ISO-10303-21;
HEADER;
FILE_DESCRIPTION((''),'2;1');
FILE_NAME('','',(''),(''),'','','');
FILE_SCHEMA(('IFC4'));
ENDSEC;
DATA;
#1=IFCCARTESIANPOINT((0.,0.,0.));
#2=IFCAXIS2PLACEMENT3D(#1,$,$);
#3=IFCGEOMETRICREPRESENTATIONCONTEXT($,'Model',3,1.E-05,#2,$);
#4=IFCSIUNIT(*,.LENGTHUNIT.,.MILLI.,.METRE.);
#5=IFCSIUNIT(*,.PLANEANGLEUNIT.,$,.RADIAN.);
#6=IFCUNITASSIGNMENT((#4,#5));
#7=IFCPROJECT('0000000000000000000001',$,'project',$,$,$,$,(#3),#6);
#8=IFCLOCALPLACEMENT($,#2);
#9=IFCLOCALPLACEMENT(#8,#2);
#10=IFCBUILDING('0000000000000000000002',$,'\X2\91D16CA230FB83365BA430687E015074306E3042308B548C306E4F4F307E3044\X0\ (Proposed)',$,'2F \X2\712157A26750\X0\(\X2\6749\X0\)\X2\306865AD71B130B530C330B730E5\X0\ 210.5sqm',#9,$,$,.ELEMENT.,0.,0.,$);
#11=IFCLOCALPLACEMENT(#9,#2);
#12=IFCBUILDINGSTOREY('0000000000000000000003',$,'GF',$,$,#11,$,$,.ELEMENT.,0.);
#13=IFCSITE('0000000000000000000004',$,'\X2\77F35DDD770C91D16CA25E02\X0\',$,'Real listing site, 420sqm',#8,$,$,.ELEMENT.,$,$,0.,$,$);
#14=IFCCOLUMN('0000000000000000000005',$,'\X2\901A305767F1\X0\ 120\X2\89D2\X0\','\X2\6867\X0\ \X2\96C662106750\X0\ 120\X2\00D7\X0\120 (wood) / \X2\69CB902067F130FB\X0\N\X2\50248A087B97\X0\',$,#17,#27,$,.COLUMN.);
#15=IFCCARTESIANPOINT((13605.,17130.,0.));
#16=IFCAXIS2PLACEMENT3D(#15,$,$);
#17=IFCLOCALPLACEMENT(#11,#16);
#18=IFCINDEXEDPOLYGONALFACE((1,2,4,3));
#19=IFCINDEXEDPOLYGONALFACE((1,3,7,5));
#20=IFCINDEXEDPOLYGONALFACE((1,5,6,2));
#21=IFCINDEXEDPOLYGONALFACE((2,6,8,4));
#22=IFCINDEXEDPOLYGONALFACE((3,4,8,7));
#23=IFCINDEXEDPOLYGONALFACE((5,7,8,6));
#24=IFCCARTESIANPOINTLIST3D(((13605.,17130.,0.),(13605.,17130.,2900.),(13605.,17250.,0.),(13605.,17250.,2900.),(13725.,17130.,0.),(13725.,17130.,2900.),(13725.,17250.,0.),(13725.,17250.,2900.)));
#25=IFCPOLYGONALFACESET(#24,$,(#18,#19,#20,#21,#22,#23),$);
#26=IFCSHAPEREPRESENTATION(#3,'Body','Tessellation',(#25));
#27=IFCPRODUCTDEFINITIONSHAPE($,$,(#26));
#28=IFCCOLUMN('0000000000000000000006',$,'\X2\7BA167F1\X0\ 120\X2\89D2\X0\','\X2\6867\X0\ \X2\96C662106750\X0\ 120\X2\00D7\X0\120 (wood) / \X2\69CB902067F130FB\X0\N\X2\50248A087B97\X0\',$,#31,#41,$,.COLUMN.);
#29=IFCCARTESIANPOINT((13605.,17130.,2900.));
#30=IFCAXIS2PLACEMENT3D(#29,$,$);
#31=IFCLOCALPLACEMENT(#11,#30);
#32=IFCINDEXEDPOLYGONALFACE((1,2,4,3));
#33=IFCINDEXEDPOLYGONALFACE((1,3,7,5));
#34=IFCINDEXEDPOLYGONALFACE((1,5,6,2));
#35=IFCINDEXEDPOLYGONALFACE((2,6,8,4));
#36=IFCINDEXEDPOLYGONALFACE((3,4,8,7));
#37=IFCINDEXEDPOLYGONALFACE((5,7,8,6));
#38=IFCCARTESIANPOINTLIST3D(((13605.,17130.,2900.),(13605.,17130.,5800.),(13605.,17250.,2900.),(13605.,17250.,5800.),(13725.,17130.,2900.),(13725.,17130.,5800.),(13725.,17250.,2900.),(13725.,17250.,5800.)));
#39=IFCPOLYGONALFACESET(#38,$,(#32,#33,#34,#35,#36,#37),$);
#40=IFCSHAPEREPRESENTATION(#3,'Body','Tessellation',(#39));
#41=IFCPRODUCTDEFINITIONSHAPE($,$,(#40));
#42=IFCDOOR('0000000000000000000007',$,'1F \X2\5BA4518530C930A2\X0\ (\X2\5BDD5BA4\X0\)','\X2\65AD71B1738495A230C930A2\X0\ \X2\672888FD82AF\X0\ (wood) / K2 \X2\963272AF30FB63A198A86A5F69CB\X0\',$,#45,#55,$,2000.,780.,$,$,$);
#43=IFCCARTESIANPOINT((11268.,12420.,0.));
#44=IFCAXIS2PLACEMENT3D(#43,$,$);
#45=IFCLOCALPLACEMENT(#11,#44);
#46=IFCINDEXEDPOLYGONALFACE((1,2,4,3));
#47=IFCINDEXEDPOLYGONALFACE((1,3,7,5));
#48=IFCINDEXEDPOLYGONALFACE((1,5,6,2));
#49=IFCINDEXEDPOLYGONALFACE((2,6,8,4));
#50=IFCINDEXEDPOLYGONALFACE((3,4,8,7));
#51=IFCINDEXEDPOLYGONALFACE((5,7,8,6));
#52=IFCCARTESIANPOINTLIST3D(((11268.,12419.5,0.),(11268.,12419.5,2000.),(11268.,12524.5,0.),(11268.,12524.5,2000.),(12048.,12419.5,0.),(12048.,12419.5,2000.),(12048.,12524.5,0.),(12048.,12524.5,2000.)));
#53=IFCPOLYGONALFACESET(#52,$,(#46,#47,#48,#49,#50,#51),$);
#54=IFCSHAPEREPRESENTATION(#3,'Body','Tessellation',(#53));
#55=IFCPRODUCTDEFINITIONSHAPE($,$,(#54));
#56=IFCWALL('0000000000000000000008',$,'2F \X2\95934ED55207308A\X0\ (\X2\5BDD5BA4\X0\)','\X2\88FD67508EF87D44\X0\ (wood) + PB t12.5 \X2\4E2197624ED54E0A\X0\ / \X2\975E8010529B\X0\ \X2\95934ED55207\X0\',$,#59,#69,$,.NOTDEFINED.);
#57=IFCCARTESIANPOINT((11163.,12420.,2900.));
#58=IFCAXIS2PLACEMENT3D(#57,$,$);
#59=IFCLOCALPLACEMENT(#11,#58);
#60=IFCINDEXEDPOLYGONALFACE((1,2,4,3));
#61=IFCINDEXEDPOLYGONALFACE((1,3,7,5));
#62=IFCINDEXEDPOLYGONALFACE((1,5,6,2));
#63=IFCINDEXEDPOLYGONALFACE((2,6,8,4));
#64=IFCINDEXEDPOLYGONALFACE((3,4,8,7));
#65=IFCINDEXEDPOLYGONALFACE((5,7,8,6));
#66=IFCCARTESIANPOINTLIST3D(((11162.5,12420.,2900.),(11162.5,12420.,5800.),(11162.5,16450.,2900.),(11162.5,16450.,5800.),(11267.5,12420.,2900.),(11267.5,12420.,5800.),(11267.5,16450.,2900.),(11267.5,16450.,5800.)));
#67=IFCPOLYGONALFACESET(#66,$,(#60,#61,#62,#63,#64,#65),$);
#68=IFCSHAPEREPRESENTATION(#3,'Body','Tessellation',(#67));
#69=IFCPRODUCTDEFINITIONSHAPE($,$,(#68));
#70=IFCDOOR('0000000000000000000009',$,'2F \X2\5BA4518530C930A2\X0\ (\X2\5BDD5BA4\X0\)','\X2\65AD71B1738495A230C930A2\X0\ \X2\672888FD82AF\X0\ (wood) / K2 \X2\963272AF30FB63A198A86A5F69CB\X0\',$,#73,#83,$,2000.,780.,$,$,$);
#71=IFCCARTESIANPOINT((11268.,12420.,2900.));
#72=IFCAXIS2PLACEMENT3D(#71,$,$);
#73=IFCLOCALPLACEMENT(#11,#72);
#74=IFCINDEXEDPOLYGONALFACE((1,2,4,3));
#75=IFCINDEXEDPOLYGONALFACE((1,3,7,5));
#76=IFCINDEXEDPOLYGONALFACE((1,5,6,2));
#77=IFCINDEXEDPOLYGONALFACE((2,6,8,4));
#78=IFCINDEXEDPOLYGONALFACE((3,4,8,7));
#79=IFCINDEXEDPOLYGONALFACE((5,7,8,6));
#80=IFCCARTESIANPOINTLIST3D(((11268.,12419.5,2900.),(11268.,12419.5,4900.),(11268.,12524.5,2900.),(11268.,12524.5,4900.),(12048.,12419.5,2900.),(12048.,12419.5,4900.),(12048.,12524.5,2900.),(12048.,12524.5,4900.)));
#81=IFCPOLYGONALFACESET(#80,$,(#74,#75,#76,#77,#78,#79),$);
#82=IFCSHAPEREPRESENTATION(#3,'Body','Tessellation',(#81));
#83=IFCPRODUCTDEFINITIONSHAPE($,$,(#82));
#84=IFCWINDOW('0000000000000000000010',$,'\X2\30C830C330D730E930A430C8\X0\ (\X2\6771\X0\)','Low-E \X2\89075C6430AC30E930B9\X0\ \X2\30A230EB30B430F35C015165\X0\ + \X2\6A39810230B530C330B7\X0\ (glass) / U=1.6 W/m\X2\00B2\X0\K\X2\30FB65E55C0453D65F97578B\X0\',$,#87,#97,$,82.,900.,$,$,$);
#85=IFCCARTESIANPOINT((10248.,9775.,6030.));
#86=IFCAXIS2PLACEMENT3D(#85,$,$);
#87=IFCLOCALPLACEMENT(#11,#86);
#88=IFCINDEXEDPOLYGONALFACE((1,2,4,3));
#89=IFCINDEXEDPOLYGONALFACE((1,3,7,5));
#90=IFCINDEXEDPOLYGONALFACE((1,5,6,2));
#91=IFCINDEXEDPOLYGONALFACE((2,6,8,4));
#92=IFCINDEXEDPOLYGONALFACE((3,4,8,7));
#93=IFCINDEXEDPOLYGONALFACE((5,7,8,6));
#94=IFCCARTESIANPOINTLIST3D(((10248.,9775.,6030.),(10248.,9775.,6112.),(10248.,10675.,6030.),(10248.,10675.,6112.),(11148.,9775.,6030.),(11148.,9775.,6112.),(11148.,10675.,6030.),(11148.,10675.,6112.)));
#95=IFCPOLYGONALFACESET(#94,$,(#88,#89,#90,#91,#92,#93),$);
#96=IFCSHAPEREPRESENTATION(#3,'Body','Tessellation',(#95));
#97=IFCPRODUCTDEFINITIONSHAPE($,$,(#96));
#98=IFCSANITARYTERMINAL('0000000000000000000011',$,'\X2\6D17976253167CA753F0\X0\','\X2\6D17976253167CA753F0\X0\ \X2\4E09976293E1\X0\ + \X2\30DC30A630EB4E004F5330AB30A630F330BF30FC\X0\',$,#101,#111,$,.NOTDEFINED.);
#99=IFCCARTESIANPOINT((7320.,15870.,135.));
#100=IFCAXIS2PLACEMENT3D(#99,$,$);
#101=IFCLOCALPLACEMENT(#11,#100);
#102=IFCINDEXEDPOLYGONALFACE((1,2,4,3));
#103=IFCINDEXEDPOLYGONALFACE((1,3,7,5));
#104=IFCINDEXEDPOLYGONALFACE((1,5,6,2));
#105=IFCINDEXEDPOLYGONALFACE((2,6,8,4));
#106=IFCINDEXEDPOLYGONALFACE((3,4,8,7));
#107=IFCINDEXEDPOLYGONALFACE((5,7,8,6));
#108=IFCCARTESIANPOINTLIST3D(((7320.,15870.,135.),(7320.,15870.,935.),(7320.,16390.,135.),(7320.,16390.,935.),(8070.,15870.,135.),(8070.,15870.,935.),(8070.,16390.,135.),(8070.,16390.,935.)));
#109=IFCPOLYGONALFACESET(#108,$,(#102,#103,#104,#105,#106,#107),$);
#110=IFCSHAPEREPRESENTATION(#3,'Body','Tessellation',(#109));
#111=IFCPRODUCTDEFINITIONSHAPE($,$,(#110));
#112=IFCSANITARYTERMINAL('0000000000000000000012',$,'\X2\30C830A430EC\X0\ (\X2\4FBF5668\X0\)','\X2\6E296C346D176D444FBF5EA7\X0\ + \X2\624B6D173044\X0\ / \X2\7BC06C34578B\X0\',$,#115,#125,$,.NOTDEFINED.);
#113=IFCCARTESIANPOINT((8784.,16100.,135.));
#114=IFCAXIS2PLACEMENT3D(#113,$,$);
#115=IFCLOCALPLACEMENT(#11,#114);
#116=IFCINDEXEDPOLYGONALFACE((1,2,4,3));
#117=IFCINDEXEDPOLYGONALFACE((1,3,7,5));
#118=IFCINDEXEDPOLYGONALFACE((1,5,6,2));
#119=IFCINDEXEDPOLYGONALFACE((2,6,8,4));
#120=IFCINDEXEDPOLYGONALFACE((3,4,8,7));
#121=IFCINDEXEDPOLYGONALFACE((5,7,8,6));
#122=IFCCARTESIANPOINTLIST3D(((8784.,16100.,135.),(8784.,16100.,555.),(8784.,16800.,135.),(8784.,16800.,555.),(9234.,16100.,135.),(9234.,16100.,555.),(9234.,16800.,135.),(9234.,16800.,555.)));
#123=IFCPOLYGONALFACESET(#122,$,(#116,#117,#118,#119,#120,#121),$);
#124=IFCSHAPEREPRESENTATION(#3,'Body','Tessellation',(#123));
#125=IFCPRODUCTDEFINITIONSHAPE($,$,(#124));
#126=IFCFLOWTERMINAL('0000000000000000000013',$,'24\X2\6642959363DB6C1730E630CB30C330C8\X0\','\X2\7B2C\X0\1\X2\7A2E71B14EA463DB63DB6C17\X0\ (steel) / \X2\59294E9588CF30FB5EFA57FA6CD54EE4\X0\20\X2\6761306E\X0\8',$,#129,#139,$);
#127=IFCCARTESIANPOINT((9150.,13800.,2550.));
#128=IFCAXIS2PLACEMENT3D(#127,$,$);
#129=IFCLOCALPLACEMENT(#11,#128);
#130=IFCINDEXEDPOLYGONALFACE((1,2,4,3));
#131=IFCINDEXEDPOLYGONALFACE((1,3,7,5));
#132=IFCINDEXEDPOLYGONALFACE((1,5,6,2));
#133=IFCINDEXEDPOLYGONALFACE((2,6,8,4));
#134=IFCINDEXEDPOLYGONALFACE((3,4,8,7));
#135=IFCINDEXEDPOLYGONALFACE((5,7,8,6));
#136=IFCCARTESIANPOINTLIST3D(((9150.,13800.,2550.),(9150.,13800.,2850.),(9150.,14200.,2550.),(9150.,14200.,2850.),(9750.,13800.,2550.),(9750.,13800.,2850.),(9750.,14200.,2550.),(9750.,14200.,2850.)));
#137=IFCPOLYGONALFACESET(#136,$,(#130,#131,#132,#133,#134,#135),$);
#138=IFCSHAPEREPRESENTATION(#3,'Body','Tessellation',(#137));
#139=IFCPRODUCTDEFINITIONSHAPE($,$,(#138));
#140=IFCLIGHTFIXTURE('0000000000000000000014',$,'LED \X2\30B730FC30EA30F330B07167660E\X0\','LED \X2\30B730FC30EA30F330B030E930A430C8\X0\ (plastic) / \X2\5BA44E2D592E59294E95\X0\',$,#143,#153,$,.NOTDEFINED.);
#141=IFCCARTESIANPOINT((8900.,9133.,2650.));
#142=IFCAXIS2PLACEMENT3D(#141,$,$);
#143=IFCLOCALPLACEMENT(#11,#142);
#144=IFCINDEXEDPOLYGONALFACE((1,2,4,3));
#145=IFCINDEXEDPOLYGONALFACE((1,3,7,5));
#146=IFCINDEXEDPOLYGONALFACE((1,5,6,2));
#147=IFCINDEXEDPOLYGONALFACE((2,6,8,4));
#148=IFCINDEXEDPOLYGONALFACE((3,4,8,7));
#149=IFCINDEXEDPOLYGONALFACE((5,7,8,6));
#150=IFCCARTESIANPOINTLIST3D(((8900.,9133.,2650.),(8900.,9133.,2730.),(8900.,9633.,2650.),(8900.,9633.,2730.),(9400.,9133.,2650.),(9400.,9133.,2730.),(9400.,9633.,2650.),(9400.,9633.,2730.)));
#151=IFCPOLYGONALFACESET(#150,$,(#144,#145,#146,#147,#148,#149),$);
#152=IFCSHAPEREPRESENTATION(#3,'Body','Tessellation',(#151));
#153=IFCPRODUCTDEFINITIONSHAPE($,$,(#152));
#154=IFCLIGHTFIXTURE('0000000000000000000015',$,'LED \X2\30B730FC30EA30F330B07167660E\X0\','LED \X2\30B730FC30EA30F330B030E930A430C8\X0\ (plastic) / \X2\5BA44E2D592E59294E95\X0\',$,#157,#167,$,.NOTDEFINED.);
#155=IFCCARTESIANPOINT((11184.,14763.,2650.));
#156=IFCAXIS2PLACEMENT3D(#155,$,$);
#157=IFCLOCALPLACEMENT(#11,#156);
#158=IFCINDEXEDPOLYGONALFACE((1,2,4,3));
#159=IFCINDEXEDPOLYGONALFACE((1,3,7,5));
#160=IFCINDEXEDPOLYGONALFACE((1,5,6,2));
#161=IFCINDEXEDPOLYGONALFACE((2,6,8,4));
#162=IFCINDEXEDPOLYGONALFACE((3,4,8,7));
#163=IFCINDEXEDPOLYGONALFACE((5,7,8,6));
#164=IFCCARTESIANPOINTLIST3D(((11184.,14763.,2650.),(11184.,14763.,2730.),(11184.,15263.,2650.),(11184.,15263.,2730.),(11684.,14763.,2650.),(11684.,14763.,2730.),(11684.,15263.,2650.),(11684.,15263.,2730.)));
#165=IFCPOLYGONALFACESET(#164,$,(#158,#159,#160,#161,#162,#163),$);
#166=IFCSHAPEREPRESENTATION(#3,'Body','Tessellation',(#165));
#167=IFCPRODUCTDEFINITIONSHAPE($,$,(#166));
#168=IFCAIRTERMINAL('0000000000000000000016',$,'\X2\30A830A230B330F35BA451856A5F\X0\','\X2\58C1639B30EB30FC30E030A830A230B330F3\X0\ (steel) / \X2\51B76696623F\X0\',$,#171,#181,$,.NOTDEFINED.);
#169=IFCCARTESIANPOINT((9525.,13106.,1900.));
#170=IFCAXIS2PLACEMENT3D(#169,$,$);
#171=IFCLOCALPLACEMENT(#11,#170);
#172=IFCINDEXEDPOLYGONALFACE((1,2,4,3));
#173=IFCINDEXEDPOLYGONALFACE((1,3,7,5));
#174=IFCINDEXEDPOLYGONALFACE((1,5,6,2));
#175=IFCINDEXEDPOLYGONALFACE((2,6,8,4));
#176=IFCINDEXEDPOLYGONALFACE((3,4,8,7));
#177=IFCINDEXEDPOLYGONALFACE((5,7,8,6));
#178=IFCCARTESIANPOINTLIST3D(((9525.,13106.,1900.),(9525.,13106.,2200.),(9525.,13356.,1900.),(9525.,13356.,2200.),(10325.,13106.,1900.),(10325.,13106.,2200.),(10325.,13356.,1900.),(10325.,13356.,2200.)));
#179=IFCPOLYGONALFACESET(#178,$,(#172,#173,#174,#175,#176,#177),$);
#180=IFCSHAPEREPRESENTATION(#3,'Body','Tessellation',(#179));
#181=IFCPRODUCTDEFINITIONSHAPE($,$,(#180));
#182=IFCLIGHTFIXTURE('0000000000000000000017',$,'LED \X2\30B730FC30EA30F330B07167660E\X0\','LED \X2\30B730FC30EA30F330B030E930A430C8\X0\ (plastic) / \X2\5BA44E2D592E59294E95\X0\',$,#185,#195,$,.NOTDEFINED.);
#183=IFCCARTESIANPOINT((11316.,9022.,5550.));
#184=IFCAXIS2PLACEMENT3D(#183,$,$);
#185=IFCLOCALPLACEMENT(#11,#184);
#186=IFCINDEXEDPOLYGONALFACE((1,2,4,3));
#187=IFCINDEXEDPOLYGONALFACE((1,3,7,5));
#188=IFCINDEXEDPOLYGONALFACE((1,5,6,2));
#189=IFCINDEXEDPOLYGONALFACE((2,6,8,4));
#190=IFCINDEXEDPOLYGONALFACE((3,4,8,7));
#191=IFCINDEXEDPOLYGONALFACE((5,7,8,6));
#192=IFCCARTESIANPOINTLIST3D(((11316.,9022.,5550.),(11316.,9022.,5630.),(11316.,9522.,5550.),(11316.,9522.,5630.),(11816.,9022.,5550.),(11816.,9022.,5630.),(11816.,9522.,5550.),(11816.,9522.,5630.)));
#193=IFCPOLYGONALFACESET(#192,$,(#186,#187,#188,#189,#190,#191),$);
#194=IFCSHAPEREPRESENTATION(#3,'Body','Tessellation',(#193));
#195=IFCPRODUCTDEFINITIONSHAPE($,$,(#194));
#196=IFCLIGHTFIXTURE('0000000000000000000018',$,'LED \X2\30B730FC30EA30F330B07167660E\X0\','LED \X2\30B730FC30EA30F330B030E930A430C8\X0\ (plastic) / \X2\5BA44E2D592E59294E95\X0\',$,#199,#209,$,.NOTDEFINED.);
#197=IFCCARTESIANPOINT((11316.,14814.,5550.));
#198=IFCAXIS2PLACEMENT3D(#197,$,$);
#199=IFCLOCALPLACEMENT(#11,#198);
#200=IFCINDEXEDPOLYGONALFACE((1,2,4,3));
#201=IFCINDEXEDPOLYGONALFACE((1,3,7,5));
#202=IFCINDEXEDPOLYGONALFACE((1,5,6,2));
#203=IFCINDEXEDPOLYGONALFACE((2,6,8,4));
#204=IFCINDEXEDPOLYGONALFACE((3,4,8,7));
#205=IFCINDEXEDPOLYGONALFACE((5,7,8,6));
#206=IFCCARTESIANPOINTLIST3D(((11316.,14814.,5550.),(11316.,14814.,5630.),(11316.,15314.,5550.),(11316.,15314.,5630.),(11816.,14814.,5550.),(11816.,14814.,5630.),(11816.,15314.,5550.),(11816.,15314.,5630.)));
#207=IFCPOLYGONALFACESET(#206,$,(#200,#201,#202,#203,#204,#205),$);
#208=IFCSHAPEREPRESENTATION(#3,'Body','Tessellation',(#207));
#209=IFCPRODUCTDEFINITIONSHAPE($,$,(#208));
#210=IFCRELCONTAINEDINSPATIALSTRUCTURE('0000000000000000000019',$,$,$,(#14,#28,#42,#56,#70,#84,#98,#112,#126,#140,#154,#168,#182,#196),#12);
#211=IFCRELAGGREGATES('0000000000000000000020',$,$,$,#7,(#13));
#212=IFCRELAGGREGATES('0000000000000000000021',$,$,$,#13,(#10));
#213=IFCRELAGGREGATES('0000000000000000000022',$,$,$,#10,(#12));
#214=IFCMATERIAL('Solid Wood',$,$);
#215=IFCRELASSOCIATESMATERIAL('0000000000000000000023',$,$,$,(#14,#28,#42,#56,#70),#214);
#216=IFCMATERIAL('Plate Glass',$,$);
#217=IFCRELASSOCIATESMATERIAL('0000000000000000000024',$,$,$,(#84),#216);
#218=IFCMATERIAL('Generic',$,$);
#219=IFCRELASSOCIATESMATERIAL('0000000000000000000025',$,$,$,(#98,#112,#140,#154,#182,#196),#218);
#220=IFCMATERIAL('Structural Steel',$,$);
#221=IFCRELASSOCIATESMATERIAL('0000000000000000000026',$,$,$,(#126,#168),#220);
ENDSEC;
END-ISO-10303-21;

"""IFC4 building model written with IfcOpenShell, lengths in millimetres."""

from ifc_helpers import new_model, si_unit, frame, frame_2d, origin, place, context, project, spatial, rectangle, extrude, material, element, save


model = new_model("IFC4")

# Units and contexts
model_context = context("Model", 3, precision=1e-05, world=origin())
ifc_project = project(units=[si_unit("LENGTHUNIT", "METRE", prefix="MILLI"), si_unit("PLANEANGLEUNIT", "RADIAN")], contexts=[model_context])

# Site, building, storey
site_placement = place(None, origin())
site = spatial("IfcSite", under=ifc_project, at=site_placement, Name="石川県金沢市", ObjectType="Real listing site, 420sqm", CompositionType="ELEMENT", RefElevation=0.0)
building_placement = place(site_placement, origin())
building = spatial("IfcBuilding", under=site, at=building_placement, Name="金沢・茶室と縁側のある和の住まい (Proposed)", ObjectType="2F 無垢材(杉)と断熱サッシュ 210.5sqm", CompositionType="ELEMENT", ElevationOfRefHeight=0.0, ElevationOfTerrain=0.0)
storey_placement = place(building_placement, origin())
storey = spatial("IfcBuildingStorey", under=building, at=storey_placement, Name="GF", CompositionType="ELEMENT", Elevation=0.0)

# Columns
ifc_material_1 = material(Name="Solid Wood")
column_1_placement = place(storey_placement, frame((13605.0, 17130.0, 0.0)))
element("IfcColumn", 1, at=column_1_placement, inside=storey, material=ifc_material_1, Name="通し柱 120角", Description="桧 集成材 120×120 (wood) / 構造柱・N値計算", PredefinedType="COLUMN", context=model_context, shape_type="SweptSolid", body=[
    extrude(rectangle(XDim=120.0, YDim=120.0, at=frame_2d((60.0, 60.0))), frame((13605.0, 17130.0, 0.0)), (0.0, 0.0, 1.0), 2900.0),
])
column_2_placement = place(storey_placement, frame((13605.0, 17130.0, 2900.0)))
element("IfcColumn", 2, at=column_2_placement, inside=storey, material=ifc_material_1, Name="管柱 120角", Description="桧 集成材 120×120 (wood) / 構造柱・N値計算", PredefinedType="COLUMN", context=model_context, shape_type="SweptSolid", body=[
    extrude(rectangle(XDim=120.0, YDim=120.0, at=frame_2d((60.0, 60.0))), frame((13605.0, 17130.0, 2900.0)), (0.0, 0.0, 1.0), 2900.0),
])

# Door
door_1_placement = place(storey_placement, frame((11268.0, 12420.0, 0.0)))
element("IfcDoor", 3, at=door_1_placement, inside=storey, material=ifc_material_1, Name="1F 室内ドア (寝室)", Description="断熱玄関ドア 木製芯 (wood) / K2 防犯・採風機構", OverallHeight=2000.0, OverallWidth=780.0, context=model_context, shape_type="SweptSolid", body=[
    extrude(rectangle(XDim=780.0, YDim=105.0, at=frame_2d((390.0, 52.0))), frame((11268.0, 12420.0, 0.0)), (0.0, 0.0, 1.0), 2000.0),
])

# Wall
wall_1_placement = place(storey_placement, frame((11163.0, 12420.0, 2900.0)))
element("IfcWall", 4, at=wall_1_placement, inside=storey, material=ifc_material_1, Name="2F 間仕切り (寝室)", Description="製材軸組 (wood) + PB t12.5 両面仕上 / 非耐力 間仕切", PredefinedType="NOTDEFINED", context=model_context, shape_type="SweptSolid", body=[
    extrude(rectangle(XDim=105.0, YDim=4030.0, at=frame_2d((52.0, 2015.0))), frame((11163.0, 12420.0, 2900.0)), (0.0, 0.0, 1.0), 2900.0),
])

# Door
door_2_placement = place(storey_placement, frame((11268.0, 12420.0, 2900.0)))
element("IfcDoor", 5, at=door_2_placement, inside=storey, material=ifc_material_1, Name="2F 室内ドア (寝室)", Description="断熱玄関ドア 木製芯 (wood) / K2 防犯・採風機構", OverallHeight=2000.0, OverallWidth=780.0, context=model_context, shape_type="SweptSolid", body=[
    extrude(rectangle(XDim=780.0, YDim=105.0, at=frame_2d((390.0, 52.0))), frame((11268.0, 12420.0, 2900.0)), (0.0, 0.0, 1.0), 2000.0),
])

# Window
ifc_material_2 = material(Name="Plate Glass")
window_placement = place(storey_placement, frame((10248.0, 9775.0, 6030.0)))
element("IfcWindow", 6, at=window_placement, inside=storey, material=ifc_material_2, Name="トップライト (東)", Description="Low-E 複層ガラス アルゴン封入 + 樹脂サッシ (glass) / U=1.6 W/m²K・日射取得型", OverallHeight=82.0, OverallWidth=900.0, context=model_context, shape_type="SweptSolid", body=[
    extrude(rectangle(XDim=900.0, YDim=900.0, at=frame_2d((450.0, 450.0))), frame((10248.0, 9775.0, 6030.0)), (0.0, 0.0, 1.0), 82.0),
])

# Sanitary terminals
ifc_material_3 = material(Name="Generic")
sanitary_terminal_1_placement = place(storey_placement, frame((7320.0, 15870.0, 135.0)))
element("IfcSanitaryTerminal", 7, at=sanitary_terminal_1_placement, inside=storey, material=ifc_material_3, Name="洗面化粧台", Description="洗面化粧台 三面鏡 + ボウル一体カウンター", PredefinedType="NOTDEFINED", context=model_context, shape_type="SweptSolid", body=[
    extrude(rectangle(XDim=750.0, YDim=520.0, at=frame_2d((375.0, 260.0))), frame((7320.0, 15870.0, 135.0)), (0.0, 0.0, 1.0), 800.0),
])
sanitary_terminal_2_placement = place(storey_placement, frame((8784.0, 16100.0, 135.0)))
element("IfcSanitaryTerminal", 8, at=sanitary_terminal_2_placement, inside=storey, material=ifc_material_3, Name="トイレ (便器)", Description="温水洗浄便座 + 手洗い / 節水型", PredefinedType="NOTDEFINED", context=model_context, shape_type="SweptSolid", body=[
    extrude(rectangle(XDim=450.0, YDim=700.0, at=frame_2d((225.0, 350.0))), frame((8784.0, 16100.0, 135.0)), (0.0, 0.0, 1.0), 420.0),
])

# Flow terminal
ifc_material_4 = material(Name="Structural Steel")
flow_terminal_placement = place(storey_placement, frame((9150.0, 13800.0, 2550.0)))
element("IfcFlowTerminal", 9, at=flow_terminal_placement, inside=storey, material=ifc_material_4, Name="24時間換気ユニット", Description="第1種熱交換換気 (steel) / 天井裏・建基法令20条の8", context=model_context, shape_type="SweptSolid", body=[
    extrude(rectangle(XDim=600.0, YDim=400.0, at=frame_2d((300.0, 200.0))), frame((9150.0, 13800.0, 2550.0)), (0.0, 0.0, 1.0), 300.0),
])

# Light fixtures
light_fixture_1_placement = place(storey_placement, frame((8900.0, 9133.0, 2650.0)))
element("IfcLightFixture", 10, at=light_fixture_1_placement, inside=storey, material=ifc_material_3, Name="LED シーリング照明", Description="LED シーリングライト (plastic) / 室中央天井", PredefinedType="NOTDEFINED", context=model_context, shape_type="SweptSolid", body=[
    extrude(rectangle(XDim=500.0, YDim=500.0, at=frame_2d((250.0, 250.0))), frame((8900.0, 9133.0, 2650.0)), (0.0, 0.0, 1.0), 80.0),
])
light_fixture_2_placement = place(storey_placement, frame((11184.0, 14763.0, 2650.0)))
element("IfcLightFixture", 11, at=light_fixture_2_placement, inside=storey, material=ifc_material_3, Name="LED シーリング照明", Description="LED シーリングライト (plastic) / 室中央天井", PredefinedType="NOTDEFINED", context=model_context, shape_type="SweptSolid", body=[
    extrude(rectangle(XDim=500.0, YDim=500.0, at=frame_2d((250.0, 250.0))), frame((11184.0, 14763.0, 2650.0)), (0.0, 0.0, 1.0), 80.0),
])

# Air terminal
air_terminal_placement = place(storey_placement, frame((9525.0, 13106.0, 1900.0)))
element("IfcAirTerminal", 12, at=air_terminal_placement, inside=storey, material=ifc_material_4, Name="エアコン室内機", Description="壁掛ルームエアコン (steel) / 冷暖房", PredefinedType="NOTDEFINED", context=model_context, shape_type="SweptSolid", body=[
    extrude(rectangle(XDim=800.0, YDim=250.0, at=frame_2d((400.0, 125.0))), frame((9525.0, 13106.0, 1900.0)), (0.0, 0.0, 1.0), 300.0),
])

# Light fixtures
light_fixture_3_placement = place(storey_placement, frame((11316.0, 9022.0, 5550.0)))
element("IfcLightFixture", 13, at=light_fixture_3_placement, inside=storey, material=ifc_material_3, Name="LED シーリング照明", Description="LED シーリングライト (plastic) / 室中央天井", PredefinedType="NOTDEFINED", context=model_context, shape_type="SweptSolid", body=[
    extrude(rectangle(XDim=500.0, YDim=500.0, at=frame_2d((250.0, 250.0))), frame((11316.0, 9022.0, 5550.0)), (0.0, 0.0, 1.0), 80.0),
])
light_fixture_4_placement = place(storey_placement, frame((11316.0, 14814.0, 5550.0)))
element("IfcLightFixture", 14, at=light_fixture_4_placement, inside=storey, material=ifc_material_3, Name="LED シーリング照明", Description="LED シーリングライト (plastic) / 室中央天井", PredefinedType="NOTDEFINED", context=model_context, shape_type="SweptSolid", body=[
    extrude(rectangle(XDim=500.0, YDim=500.0, at=frame_2d((250.0, 250.0))), frame((11316.0, 14814.0, 5550.0)), (0.0, 0.0, 1.0), 80.0),
])

save(model, "model.ifc")
